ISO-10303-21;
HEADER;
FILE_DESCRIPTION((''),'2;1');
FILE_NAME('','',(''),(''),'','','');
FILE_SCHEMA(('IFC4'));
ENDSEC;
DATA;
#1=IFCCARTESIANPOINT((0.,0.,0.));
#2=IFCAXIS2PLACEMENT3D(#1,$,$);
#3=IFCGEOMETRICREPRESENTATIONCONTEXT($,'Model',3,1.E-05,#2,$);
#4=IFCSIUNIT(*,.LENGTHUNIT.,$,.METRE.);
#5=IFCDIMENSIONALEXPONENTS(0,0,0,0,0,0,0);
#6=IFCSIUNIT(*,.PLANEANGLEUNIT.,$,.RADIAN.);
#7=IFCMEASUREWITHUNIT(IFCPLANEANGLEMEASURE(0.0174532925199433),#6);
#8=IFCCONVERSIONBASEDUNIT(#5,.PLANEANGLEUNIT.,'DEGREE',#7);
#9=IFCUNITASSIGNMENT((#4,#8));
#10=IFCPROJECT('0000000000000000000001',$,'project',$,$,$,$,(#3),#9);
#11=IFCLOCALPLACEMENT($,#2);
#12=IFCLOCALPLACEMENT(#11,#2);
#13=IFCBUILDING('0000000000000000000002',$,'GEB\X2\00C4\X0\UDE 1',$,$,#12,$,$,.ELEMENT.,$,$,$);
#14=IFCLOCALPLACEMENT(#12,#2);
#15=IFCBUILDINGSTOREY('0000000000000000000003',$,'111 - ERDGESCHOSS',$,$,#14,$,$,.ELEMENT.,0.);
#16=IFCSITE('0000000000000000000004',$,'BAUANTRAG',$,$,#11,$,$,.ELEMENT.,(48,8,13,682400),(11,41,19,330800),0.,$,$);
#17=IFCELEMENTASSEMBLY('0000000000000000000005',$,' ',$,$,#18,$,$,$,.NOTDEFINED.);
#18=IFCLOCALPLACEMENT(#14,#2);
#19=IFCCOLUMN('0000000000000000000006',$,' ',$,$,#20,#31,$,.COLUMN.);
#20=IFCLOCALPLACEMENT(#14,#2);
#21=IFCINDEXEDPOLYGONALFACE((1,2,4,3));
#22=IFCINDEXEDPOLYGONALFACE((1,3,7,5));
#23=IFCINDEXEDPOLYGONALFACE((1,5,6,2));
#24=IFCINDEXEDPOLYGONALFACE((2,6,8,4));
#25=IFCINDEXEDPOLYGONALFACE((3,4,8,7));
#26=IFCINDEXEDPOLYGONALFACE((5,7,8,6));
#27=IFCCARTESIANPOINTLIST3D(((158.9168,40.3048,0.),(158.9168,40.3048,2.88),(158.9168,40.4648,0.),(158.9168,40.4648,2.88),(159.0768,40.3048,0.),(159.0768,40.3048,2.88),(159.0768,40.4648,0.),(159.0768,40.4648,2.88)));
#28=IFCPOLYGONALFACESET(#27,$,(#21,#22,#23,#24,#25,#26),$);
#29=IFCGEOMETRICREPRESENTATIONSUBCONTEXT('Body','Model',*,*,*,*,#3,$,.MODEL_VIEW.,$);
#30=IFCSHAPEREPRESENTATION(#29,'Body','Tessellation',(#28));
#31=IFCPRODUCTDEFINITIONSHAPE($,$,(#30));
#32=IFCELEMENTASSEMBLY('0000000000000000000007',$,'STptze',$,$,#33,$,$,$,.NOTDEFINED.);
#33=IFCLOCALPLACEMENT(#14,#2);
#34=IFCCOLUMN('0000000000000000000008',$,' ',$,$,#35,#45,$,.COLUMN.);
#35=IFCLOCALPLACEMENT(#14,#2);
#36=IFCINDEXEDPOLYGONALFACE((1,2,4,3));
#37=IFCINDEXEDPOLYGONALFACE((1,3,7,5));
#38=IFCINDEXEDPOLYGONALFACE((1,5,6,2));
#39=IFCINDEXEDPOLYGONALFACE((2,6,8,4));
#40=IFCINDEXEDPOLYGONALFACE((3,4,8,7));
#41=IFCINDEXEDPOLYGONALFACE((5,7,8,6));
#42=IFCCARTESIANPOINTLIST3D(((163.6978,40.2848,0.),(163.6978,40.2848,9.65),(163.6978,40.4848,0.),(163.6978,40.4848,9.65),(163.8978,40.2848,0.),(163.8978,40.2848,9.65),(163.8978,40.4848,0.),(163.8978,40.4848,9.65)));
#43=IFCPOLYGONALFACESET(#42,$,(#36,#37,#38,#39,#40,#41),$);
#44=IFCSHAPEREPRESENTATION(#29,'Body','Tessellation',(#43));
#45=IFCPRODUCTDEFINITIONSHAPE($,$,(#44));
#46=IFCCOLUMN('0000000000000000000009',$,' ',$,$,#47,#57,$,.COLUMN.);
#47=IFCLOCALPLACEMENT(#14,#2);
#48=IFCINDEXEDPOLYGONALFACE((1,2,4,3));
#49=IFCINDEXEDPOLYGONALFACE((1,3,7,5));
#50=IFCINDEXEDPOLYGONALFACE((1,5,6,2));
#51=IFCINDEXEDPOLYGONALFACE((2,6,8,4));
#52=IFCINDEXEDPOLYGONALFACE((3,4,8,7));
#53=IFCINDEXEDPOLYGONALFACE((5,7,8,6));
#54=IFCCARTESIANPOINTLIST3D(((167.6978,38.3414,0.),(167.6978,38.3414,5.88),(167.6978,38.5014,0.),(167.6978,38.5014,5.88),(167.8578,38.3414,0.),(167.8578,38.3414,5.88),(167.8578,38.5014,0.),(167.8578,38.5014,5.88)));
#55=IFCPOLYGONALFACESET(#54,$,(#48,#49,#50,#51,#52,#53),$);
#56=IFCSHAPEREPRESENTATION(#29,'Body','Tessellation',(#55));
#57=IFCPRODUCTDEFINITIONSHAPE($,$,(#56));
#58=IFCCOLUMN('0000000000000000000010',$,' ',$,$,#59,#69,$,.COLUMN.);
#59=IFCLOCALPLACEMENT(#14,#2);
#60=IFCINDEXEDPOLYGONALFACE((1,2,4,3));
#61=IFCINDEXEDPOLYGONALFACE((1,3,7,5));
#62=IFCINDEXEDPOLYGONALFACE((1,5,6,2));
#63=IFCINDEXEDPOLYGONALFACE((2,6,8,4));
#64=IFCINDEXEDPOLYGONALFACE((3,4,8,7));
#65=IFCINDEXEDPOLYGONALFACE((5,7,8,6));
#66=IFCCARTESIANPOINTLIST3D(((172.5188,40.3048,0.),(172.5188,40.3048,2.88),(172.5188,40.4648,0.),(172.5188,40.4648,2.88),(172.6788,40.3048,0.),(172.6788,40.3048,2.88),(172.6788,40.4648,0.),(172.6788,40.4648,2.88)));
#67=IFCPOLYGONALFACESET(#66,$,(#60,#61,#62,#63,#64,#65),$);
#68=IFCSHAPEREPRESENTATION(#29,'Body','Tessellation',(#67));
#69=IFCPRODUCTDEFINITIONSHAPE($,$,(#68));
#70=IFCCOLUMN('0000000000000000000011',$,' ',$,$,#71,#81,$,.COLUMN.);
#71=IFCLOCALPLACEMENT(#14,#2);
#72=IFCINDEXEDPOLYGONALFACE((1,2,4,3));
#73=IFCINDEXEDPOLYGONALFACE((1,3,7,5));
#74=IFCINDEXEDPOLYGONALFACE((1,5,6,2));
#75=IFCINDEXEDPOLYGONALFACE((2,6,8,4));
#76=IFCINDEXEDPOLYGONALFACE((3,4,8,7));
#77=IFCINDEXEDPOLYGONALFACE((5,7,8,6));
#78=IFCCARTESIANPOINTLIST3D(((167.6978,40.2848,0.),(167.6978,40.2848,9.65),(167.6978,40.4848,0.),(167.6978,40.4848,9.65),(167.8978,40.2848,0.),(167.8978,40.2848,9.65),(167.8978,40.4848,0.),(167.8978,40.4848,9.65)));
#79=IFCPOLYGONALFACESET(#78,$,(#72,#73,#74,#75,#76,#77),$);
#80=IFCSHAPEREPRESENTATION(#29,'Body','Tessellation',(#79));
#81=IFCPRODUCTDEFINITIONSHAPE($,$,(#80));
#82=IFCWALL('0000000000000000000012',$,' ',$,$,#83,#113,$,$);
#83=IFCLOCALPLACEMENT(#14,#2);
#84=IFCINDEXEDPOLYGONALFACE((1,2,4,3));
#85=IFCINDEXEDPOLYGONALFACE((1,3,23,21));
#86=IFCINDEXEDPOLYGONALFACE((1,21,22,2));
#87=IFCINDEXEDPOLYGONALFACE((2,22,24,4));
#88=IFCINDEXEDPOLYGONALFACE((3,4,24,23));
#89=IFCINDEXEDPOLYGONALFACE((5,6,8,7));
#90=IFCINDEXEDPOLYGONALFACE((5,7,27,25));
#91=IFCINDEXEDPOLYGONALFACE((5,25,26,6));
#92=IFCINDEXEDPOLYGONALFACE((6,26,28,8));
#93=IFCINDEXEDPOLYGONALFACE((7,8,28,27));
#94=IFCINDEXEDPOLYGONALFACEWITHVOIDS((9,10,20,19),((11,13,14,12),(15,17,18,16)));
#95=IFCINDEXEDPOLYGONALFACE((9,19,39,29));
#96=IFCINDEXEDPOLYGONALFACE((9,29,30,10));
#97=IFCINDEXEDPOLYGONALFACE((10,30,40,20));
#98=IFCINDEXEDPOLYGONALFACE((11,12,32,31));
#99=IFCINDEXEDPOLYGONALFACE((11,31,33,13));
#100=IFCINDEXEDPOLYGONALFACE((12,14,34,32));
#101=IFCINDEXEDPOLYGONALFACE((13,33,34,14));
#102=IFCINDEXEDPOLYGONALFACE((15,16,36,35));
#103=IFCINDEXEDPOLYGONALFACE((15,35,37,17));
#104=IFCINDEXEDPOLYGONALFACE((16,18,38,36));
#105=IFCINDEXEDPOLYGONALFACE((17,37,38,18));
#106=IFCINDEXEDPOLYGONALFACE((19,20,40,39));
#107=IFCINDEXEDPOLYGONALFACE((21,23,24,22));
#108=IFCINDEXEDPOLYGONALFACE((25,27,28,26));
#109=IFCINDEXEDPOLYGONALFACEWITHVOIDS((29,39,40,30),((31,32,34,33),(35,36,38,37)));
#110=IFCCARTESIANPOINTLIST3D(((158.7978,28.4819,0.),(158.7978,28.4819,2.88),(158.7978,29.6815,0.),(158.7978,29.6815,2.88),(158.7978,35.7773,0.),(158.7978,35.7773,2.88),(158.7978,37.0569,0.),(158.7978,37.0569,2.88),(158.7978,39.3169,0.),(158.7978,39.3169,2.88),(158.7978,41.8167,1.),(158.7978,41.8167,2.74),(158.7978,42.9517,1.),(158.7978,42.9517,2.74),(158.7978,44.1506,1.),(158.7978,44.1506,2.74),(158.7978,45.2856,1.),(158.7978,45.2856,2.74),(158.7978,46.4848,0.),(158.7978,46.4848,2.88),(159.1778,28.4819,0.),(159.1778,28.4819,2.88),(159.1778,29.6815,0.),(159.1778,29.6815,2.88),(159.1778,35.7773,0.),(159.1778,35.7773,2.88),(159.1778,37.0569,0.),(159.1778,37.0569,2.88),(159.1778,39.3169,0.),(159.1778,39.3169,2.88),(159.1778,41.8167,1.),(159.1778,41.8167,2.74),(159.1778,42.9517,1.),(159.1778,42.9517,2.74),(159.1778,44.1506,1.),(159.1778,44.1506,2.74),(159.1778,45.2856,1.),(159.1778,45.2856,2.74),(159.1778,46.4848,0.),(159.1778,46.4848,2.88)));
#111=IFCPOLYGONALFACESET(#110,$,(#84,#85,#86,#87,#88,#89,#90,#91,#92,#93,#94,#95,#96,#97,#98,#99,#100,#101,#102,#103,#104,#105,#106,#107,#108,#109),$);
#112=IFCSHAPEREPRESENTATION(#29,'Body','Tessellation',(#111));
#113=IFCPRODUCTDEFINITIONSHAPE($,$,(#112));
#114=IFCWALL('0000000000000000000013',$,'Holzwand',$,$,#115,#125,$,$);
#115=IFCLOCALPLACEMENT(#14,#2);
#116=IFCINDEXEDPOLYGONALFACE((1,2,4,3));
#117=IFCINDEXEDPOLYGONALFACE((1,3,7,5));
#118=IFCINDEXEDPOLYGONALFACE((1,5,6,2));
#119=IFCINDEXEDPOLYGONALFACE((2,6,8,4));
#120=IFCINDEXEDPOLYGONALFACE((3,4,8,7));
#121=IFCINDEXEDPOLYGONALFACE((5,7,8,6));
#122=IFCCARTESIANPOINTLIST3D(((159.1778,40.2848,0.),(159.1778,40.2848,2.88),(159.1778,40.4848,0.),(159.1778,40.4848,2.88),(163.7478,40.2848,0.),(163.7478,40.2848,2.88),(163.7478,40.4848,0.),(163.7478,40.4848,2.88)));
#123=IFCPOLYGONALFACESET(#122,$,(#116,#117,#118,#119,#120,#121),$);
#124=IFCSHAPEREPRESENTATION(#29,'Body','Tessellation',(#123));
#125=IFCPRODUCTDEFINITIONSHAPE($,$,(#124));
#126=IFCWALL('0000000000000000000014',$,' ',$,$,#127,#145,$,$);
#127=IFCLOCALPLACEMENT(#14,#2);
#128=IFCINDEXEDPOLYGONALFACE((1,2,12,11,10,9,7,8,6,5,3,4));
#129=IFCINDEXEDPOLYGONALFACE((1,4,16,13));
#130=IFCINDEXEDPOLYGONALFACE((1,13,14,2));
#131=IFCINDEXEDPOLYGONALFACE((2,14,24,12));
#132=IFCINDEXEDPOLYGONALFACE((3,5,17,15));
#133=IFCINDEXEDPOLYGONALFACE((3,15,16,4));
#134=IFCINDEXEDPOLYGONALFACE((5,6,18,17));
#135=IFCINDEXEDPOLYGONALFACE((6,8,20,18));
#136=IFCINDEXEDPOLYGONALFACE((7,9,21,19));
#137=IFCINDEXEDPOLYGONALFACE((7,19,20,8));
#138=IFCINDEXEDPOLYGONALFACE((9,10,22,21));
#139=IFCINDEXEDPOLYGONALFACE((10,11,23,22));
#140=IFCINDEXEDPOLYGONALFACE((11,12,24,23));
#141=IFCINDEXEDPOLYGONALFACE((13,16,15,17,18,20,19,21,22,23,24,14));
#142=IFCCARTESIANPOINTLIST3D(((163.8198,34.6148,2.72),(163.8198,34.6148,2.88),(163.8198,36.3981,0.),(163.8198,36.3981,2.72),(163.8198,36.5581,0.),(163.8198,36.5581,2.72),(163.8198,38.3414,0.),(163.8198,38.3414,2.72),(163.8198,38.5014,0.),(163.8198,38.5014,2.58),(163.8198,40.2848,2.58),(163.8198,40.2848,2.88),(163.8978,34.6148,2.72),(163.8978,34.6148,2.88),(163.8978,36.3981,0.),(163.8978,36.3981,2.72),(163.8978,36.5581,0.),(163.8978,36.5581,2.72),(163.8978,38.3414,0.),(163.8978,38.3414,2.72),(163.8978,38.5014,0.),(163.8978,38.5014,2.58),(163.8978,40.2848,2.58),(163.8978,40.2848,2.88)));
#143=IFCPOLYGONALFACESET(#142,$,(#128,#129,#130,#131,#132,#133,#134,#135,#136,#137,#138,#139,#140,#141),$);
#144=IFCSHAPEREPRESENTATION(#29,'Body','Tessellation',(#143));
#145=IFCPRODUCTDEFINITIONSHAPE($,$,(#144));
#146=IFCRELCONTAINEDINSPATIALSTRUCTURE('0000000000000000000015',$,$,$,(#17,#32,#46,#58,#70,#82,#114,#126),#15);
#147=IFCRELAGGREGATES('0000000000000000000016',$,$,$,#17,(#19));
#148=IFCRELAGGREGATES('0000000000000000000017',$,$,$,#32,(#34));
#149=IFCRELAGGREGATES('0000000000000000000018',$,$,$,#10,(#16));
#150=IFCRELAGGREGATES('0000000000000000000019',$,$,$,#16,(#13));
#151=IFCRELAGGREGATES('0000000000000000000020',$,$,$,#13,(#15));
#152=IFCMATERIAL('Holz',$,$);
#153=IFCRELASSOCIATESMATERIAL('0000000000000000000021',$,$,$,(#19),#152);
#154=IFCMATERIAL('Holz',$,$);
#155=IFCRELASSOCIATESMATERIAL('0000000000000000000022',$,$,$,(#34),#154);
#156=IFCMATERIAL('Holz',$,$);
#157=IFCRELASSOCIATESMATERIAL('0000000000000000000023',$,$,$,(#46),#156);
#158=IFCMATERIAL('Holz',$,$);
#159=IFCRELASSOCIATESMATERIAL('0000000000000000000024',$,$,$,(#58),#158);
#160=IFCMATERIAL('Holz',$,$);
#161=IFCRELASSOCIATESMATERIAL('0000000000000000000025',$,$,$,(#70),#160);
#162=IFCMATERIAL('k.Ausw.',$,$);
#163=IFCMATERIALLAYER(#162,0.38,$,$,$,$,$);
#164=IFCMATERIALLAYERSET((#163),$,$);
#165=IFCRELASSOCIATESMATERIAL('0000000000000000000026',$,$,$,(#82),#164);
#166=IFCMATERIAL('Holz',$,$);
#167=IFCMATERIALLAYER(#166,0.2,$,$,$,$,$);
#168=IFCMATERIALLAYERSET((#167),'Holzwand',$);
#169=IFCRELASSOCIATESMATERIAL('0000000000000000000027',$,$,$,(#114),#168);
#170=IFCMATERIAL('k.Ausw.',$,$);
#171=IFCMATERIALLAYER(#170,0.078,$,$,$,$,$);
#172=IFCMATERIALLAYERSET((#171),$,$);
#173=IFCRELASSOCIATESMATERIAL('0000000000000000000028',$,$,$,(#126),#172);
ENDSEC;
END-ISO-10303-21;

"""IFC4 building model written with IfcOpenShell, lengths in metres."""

from ifc_helpers import new_model, entity, si_unit, converted_unit, frame, frame_2d, origin, origin_with_axes, place, context, subcontext, project, spatial, polyline, rectangle, outline, extrude, material, layer, layer_set, layer_usage, element, aggregate, save


model = new_model("IFC4")

# Units and contexts
model_context = context("Model", 3, precision=1e-05, world=origin())
body_context = subcontext(model_context, "Body", "Model", "MODEL_VIEW")
ifc_project = project(units=[si_unit("LENGTHUNIT", "METRE"), converted_unit("PLANEANGLEUNIT", "DEGREE", entity("IfcPlaneAngleMeasure", 0.0174532925199433), si_unit("PLANEANGLEUNIT", "RADIAN"), dimensions=[0, 0, 0, 0, 0, 0, 0])], contexts=[model_context])

# Site, building, storey
site_placement = place(None, origin())
site = spatial("IfcSite", under=ifc_project, at=site_placement, Name="BAUANTRAG", CompositionType="ELEMENT", RefLatitude=(48, 8, 13, 682400), RefLongitude=(11, 41, 19, 330800), RefElevation=0.0)
building_placement = place(site_placement, origin())
building = spatial("IfcBuilding", under=site, at=building_placement, Name="GEBÄUDE 1", CompositionType="ELEMENT")
storey_placement = place(building_placement, origin())
storey = spatial("IfcBuildingStorey", under=building, at=storey_placement, Name="111 - ERDGESCHOSS", CompositionType="ELEMENT", Elevation=0.0)

# Element assemblies, columns
assembly_1_placement = place(storey_placement, origin())
assembly_1 = element("IfcElementAssembly", 1, at=assembly_1_placement, inside=storey, Name=" ", PredefinedType="NOTDEFINED")
ifc_material_1 = material(Name="Holz")
column_1_placement = place(assembly_1_placement, frame((158.9168, 40.3048, 0.0)))
column_1 = element("IfcColumn", 2, at=column_1_placement, material=ifc_material_1, Name=" ", PredefinedType="COLUMN", context=body_context, shape_type="SweptSolid", body=[
    extrude(rectangle(XDim=0.16, YDim=0.16, at=frame_2d((0.08, 0.08), x_axis=(1.0, 0.0))), origin_with_axes(), (0.0, 0.0, 1.0), 2.88),
])
aggregate(assembly_1, [column_1])
assembly_2_placement = place(storey_placement, origin())
assembly_2 = element("IfcElementAssembly", 3, at=assembly_2_placement, inside=storey, Name="STptze", PredefinedType="NOTDEFINED")
ifc_material_2 = material(Name="Holz")
column_2_placement = place(assembly_2_placement, frame((163.6978, 40.2848, 0.0)))
column_2 = element("IfcColumn", 4, at=column_2_placement, material=ifc_material_2, Name=" ", PredefinedType="COLUMN", context=body_context, shape_type="SweptSolid", body=[
    extrude(rectangle(XDim=0.2, YDim=0.2, at=frame_2d((0.1, 0.1), x_axis=(1.0, 0.0))), origin_with_axes(), (0.0, 0.0, 1.0), 9.65),
])
aggregate(assembly_2, [column_2])

# Columns
ifc_material_3 = material(Name="Holz")
column_3_placement = place(storey_placement, frame((167.6978, 38.3414, 0.0)))
element("IfcColumn", 5, at=column_3_placement, inside=storey, material=ifc_material_3, Name=" ", PredefinedType="COLUMN", context=body_context, shape_type="SweptSolid", body=[
    extrude(rectangle(XDim=0.16, YDim=0.16, at=frame_2d((0.08, 0.08), x_axis=(1.0, 0.0))), origin_with_axes(), (0.0, 0.0, 1.0), 5.88),
])
ifc_material_4 = material(Name="Holz")
column_4_placement = place(storey_placement, frame((172.5188, 40.3048, 0.0)))
element("IfcColumn", 6, at=column_4_placement, inside=storey, material=ifc_material_4, Name=" ", PredefinedType="COLUMN", context=body_context, shape_type="SweptSolid", body=[
    extrude(rectangle(XDim=0.16, YDim=0.16, at=frame_2d((0.08, 0.08), x_axis=(1.0, 0.0))), origin_with_axes(), (0.0, 0.0, 1.0), 2.88),
])
ifc_material_5 = material(Name="Holz")
column_5_placement = place(storey_placement, frame((167.6978, 40.2848, 0.0)))
element("IfcColumn", 7, at=column_5_placement, inside=storey, material=ifc_material_5, Name=" ", PredefinedType="COLUMN", context=body_context, shape_type="SweptSolid", body=[
    extrude(rectangle(XDim=0.2, YDim=0.2, at=frame_2d((0.1, 0.1), x_axis=(1.0, 0.0))), origin_with_axes(), (0.0, 0.0, 1.0), 9.65),
])

# Wall, openings
ifc_material_6 = material(Name="k.Ausw.")
ifc_layer_1 = layer(ifc_material_6, 0.38)
ifc_layer_set_1 = layer_set([ifc_layer_1])
ifc_layer_usage_1 = layer_usage(ifc_layer_set_1, "AXIS2", "POSITIVE", 0.0)
wall_1_placement = place(storey_placement, frame((158.7978, 46.4848, 0.0), z_axis=(0.0, 0.0, 1.0), x_axis=(0.0, -1.0, 0.0)))
wall_1 = element("IfcWall", 8, at=wall_1_placement, inside=storey, material=ifc_layer_usage_1, Name=" ", context=body_context, shape_type="SweptSolid", body=[
    extrude(rectangle(XDim=18.0029, YDim=0.38, at=frame_2d((9.0014, 0.19), x_axis=(1.0, 0.0))), origin_with_axes(), (0.0, 0.0, 1.0), 2.88),
])
opening_1_placement = place(wall_1_placement, frame((12.0614, 0.0, 0.0), z_axis=(0.0, 1.0, 0.0), x_axis=(0.0, 0.0, 1.0)))
element("IfcOpeningElement", 9, at=opening_1_placement, cuts=wall_1, ObjectType="Opening", context=body_context, shape_type="SweptSolid", body=[
    extrude(outline(polyline([(0.0, 3.608), (2.88, 3.608), (2.88, 0.0), (0.0, 0.0), (0.0, 3.608)])), origin_with_axes(), (0.0, 0.0, 1.0), 0.38),
])
opening_2_placement = place(wall_1_placement, frame((10.7075, 0.0, 0.0), z_axis=(0.0, 1.0, 0.0), x_axis=(0.0, 0.0, 1.0)))
element("IfcOpeningElement", 10, at=opening_2_placement, cuts=wall_1, ObjectType="Opening", context=body_context, shape_type="SweptSolid", body=[
    extrude(outline(polyline([(0.0, 1.3539), (2.88, 1.3539), (2.88, 0.0), (0.0, 0.0), (0.0, 1.3539)])), origin_with_axes(), (0.0, 0.0, 1.0), 0.38),
])
opening_3_placement = place(wall_1_placement, frame((7.1679, 0.0, 0.0), z_axis=(0.0, 1.0, 0.0), x_axis=(0.0, 0.0, 1.0)))
element("IfcOpeningElement", 11, at=opening_3_placement, cuts=wall_1, ObjectType="Opening", context=body_context, shape_type="SweptSolid", body=[
    extrude(outline(polyline([(0.0, 2.26), (2.88, 2.26), (2.88, 0.0), (0.0, 0.0), (0.0, 2.26)])), origin_with_axes(), (0.0, 0.0, 1.0), 0.38),
])
opening_4_placement = place(wall_1_placement, frame((1.1992, 0.0, 1.0), z_axis=(0.0, 1.0, 0.0), x_axis=(0.0, 0.0, 1.0)))
element("IfcOpeningElement", 12, at=opening_4_placement, cuts=wall_1, ObjectType="Opening", context=body_context, shape_type="SweptSolid", body=[
    extrude(outline(polyline([(0.0, 1.135), (1.74, 1.135), (1.74, 0.0), (0.0, 0.0), (0.0, 1.135)])), origin_with_axes(), (0.0, 0.0, 1.0), 0.38),
])
opening_5_placement = place(wall_1_placement, frame((3.5331, 0.0, 1.0), z_axis=(0.0, 1.0, 0.0), x_axis=(0.0, 0.0, 1.0)))
element("IfcOpeningElement", 13, at=opening_5_placement, cuts=wall_1, ObjectType="Opening", context=body_context, shape_type="SweptSolid", body=[
    extrude(outline(polyline([(0.0, 1.135), (1.74, 1.135), (1.74, 0.0), (0.0, 0.0), (0.0, 1.135)])), origin_with_axes(), (0.0, 0.0, 1.0), 0.38),
])
opening_6_placement = place(wall_1_placement, frame((15.6683, 0.0, 0.0), z_axis=(0.0, 1.0, 0.0), x_axis=(0.0, 0.0, 1.0)))
element("IfcOpeningElement", 14, at=opening_6_placement, cuts=wall_1, ObjectType="Opening", context=body_context, shape_type="SweptSolid", body=[
    extrude(outline(polyline([(0.0, 1.135), (2.88, 1.135), (2.88, 0.0), (0.0, 0.0), (0.0, 1.135)])), origin_with_axes(), (0.0, 0.0, 1.0), 0.38),
])

# Wall
ifc_material_7 = material(Name="Holz")
ifc_layer_2 = layer(ifc_material_7, 0.2)
ifc_layer_set_2 = layer_set([ifc_layer_2], Name="Holzwand")
ifc_layer_usage_2 = layer_usage(ifc_layer_set_2, "AXIS2", "POSITIVE", 0.0)
wall_2_placement = place(storey_placement, frame((163.7478, 40.4848, 0.0), z_axis=(0.0, 0.0, 1.0), x_axis=(-1.0, 0.0, 0.0)))
element("IfcWall", 15, at=wall_2_placement, inside=storey, material=ifc_layer_usage_2, Name="Holzwand", context=body_context, shape_type="SweptSolid", body=[
    extrude(rectangle(XDim=4.57, YDim=0.2, at=frame_2d((2.285, 0.1), x_axis=(1.0, 0.0))), origin_with_axes(), (0.0, 0.0, 1.0), 2.88),
])

# Wall, openings
ifc_material_8 = material(Name="k.Ausw.")
ifc_layer_3 = layer(ifc_material_8, 0.078)
ifc_layer_set_3 = layer_set([ifc_layer_3])
ifc_layer_usage_3 = layer_usage(ifc_layer_set_3, "AXIS2", "POSITIVE", 0.0)
wall_3_placement = place(storey_placement, frame((163.8198, 40.2848, 0.0), z_axis=(0.0, 0.0, 1.0), x_axis=(0.0, -1.0, 0.0)))
wall_3 = element("IfcWall", 16, at=wall_3_placement, inside=storey, material=ifc_layer_usage_3, Name=" ", context=body_context, shape_type="SweptSolid", body=[
    extrude(rectangle(XDim=5.67, YDim=0.078, at=frame_2d((2.835, 0.039), x_axis=(1.0, 0.0))), origin_with_axes(), (0.0, 0.0, 1.0), 2.88),
])
opening_7_placement = place(wall_3_placement, frame((1.9434, 0.0, 0.0), z_axis=(0.0, 1.0, 0.0), x_axis=(0.0, 0.0, 1.0)))
element("IfcOpeningElement", 17, at=opening_7_placement, cuts=wall_3, ObjectType="Opening", context=body_context, shape_type="SweptSolid", body=[
    extrude(outline(polyline([(0.0, 1.7833), (2.72, 1.7833), (2.72, 0.0), (0.0, 0.0), (0.0, 1.7833)])), origin_with_axes(), (0.0, 0.0, 1.0), 0.078),
])
opening_8_placement = place(wall_3_placement, frame((3.8867, 0.0, 0.0), z_axis=(0.0, 1.0, 0.0), x_axis=(0.0, 0.0, 1.0)))
element("IfcOpeningElement", 18, at=opening_8_placement, cuts=wall_3, ObjectType="Opening", context=body_context, shape_type="SweptSolid", body=[
    extrude(outline(polyline([(0.0, 1.7833), (2.72, 1.7833), (2.72, 0.0), (0.0, 0.0), (0.0, 1.7833)])), origin_with_axes(), (0.0, 0.0, 1.0), 0.078),
])
opening_9_placement = place(wall_3_placement, frame((0.0, 0.0, -0.14), z_axis=(0.0, 1.0, 0.0), x_axis=(0.0, 0.0, 1.0)))
element("IfcOpeningElement", 19, at=opening_9_placement, cuts=wall_3, ObjectType="Opening", context=body_context, shape_type="SweptSolid", body=[
    extrude(outline(polyline([(0.0, 1.7834), (2.72, 1.7834), (2.72, 0.0), (0.0, 0.0), (0.0, 1.7834)])), origin_with_axes(), (0.0, 0.0, 1.0), 0.078),
])

save(model, "model.ifc")
